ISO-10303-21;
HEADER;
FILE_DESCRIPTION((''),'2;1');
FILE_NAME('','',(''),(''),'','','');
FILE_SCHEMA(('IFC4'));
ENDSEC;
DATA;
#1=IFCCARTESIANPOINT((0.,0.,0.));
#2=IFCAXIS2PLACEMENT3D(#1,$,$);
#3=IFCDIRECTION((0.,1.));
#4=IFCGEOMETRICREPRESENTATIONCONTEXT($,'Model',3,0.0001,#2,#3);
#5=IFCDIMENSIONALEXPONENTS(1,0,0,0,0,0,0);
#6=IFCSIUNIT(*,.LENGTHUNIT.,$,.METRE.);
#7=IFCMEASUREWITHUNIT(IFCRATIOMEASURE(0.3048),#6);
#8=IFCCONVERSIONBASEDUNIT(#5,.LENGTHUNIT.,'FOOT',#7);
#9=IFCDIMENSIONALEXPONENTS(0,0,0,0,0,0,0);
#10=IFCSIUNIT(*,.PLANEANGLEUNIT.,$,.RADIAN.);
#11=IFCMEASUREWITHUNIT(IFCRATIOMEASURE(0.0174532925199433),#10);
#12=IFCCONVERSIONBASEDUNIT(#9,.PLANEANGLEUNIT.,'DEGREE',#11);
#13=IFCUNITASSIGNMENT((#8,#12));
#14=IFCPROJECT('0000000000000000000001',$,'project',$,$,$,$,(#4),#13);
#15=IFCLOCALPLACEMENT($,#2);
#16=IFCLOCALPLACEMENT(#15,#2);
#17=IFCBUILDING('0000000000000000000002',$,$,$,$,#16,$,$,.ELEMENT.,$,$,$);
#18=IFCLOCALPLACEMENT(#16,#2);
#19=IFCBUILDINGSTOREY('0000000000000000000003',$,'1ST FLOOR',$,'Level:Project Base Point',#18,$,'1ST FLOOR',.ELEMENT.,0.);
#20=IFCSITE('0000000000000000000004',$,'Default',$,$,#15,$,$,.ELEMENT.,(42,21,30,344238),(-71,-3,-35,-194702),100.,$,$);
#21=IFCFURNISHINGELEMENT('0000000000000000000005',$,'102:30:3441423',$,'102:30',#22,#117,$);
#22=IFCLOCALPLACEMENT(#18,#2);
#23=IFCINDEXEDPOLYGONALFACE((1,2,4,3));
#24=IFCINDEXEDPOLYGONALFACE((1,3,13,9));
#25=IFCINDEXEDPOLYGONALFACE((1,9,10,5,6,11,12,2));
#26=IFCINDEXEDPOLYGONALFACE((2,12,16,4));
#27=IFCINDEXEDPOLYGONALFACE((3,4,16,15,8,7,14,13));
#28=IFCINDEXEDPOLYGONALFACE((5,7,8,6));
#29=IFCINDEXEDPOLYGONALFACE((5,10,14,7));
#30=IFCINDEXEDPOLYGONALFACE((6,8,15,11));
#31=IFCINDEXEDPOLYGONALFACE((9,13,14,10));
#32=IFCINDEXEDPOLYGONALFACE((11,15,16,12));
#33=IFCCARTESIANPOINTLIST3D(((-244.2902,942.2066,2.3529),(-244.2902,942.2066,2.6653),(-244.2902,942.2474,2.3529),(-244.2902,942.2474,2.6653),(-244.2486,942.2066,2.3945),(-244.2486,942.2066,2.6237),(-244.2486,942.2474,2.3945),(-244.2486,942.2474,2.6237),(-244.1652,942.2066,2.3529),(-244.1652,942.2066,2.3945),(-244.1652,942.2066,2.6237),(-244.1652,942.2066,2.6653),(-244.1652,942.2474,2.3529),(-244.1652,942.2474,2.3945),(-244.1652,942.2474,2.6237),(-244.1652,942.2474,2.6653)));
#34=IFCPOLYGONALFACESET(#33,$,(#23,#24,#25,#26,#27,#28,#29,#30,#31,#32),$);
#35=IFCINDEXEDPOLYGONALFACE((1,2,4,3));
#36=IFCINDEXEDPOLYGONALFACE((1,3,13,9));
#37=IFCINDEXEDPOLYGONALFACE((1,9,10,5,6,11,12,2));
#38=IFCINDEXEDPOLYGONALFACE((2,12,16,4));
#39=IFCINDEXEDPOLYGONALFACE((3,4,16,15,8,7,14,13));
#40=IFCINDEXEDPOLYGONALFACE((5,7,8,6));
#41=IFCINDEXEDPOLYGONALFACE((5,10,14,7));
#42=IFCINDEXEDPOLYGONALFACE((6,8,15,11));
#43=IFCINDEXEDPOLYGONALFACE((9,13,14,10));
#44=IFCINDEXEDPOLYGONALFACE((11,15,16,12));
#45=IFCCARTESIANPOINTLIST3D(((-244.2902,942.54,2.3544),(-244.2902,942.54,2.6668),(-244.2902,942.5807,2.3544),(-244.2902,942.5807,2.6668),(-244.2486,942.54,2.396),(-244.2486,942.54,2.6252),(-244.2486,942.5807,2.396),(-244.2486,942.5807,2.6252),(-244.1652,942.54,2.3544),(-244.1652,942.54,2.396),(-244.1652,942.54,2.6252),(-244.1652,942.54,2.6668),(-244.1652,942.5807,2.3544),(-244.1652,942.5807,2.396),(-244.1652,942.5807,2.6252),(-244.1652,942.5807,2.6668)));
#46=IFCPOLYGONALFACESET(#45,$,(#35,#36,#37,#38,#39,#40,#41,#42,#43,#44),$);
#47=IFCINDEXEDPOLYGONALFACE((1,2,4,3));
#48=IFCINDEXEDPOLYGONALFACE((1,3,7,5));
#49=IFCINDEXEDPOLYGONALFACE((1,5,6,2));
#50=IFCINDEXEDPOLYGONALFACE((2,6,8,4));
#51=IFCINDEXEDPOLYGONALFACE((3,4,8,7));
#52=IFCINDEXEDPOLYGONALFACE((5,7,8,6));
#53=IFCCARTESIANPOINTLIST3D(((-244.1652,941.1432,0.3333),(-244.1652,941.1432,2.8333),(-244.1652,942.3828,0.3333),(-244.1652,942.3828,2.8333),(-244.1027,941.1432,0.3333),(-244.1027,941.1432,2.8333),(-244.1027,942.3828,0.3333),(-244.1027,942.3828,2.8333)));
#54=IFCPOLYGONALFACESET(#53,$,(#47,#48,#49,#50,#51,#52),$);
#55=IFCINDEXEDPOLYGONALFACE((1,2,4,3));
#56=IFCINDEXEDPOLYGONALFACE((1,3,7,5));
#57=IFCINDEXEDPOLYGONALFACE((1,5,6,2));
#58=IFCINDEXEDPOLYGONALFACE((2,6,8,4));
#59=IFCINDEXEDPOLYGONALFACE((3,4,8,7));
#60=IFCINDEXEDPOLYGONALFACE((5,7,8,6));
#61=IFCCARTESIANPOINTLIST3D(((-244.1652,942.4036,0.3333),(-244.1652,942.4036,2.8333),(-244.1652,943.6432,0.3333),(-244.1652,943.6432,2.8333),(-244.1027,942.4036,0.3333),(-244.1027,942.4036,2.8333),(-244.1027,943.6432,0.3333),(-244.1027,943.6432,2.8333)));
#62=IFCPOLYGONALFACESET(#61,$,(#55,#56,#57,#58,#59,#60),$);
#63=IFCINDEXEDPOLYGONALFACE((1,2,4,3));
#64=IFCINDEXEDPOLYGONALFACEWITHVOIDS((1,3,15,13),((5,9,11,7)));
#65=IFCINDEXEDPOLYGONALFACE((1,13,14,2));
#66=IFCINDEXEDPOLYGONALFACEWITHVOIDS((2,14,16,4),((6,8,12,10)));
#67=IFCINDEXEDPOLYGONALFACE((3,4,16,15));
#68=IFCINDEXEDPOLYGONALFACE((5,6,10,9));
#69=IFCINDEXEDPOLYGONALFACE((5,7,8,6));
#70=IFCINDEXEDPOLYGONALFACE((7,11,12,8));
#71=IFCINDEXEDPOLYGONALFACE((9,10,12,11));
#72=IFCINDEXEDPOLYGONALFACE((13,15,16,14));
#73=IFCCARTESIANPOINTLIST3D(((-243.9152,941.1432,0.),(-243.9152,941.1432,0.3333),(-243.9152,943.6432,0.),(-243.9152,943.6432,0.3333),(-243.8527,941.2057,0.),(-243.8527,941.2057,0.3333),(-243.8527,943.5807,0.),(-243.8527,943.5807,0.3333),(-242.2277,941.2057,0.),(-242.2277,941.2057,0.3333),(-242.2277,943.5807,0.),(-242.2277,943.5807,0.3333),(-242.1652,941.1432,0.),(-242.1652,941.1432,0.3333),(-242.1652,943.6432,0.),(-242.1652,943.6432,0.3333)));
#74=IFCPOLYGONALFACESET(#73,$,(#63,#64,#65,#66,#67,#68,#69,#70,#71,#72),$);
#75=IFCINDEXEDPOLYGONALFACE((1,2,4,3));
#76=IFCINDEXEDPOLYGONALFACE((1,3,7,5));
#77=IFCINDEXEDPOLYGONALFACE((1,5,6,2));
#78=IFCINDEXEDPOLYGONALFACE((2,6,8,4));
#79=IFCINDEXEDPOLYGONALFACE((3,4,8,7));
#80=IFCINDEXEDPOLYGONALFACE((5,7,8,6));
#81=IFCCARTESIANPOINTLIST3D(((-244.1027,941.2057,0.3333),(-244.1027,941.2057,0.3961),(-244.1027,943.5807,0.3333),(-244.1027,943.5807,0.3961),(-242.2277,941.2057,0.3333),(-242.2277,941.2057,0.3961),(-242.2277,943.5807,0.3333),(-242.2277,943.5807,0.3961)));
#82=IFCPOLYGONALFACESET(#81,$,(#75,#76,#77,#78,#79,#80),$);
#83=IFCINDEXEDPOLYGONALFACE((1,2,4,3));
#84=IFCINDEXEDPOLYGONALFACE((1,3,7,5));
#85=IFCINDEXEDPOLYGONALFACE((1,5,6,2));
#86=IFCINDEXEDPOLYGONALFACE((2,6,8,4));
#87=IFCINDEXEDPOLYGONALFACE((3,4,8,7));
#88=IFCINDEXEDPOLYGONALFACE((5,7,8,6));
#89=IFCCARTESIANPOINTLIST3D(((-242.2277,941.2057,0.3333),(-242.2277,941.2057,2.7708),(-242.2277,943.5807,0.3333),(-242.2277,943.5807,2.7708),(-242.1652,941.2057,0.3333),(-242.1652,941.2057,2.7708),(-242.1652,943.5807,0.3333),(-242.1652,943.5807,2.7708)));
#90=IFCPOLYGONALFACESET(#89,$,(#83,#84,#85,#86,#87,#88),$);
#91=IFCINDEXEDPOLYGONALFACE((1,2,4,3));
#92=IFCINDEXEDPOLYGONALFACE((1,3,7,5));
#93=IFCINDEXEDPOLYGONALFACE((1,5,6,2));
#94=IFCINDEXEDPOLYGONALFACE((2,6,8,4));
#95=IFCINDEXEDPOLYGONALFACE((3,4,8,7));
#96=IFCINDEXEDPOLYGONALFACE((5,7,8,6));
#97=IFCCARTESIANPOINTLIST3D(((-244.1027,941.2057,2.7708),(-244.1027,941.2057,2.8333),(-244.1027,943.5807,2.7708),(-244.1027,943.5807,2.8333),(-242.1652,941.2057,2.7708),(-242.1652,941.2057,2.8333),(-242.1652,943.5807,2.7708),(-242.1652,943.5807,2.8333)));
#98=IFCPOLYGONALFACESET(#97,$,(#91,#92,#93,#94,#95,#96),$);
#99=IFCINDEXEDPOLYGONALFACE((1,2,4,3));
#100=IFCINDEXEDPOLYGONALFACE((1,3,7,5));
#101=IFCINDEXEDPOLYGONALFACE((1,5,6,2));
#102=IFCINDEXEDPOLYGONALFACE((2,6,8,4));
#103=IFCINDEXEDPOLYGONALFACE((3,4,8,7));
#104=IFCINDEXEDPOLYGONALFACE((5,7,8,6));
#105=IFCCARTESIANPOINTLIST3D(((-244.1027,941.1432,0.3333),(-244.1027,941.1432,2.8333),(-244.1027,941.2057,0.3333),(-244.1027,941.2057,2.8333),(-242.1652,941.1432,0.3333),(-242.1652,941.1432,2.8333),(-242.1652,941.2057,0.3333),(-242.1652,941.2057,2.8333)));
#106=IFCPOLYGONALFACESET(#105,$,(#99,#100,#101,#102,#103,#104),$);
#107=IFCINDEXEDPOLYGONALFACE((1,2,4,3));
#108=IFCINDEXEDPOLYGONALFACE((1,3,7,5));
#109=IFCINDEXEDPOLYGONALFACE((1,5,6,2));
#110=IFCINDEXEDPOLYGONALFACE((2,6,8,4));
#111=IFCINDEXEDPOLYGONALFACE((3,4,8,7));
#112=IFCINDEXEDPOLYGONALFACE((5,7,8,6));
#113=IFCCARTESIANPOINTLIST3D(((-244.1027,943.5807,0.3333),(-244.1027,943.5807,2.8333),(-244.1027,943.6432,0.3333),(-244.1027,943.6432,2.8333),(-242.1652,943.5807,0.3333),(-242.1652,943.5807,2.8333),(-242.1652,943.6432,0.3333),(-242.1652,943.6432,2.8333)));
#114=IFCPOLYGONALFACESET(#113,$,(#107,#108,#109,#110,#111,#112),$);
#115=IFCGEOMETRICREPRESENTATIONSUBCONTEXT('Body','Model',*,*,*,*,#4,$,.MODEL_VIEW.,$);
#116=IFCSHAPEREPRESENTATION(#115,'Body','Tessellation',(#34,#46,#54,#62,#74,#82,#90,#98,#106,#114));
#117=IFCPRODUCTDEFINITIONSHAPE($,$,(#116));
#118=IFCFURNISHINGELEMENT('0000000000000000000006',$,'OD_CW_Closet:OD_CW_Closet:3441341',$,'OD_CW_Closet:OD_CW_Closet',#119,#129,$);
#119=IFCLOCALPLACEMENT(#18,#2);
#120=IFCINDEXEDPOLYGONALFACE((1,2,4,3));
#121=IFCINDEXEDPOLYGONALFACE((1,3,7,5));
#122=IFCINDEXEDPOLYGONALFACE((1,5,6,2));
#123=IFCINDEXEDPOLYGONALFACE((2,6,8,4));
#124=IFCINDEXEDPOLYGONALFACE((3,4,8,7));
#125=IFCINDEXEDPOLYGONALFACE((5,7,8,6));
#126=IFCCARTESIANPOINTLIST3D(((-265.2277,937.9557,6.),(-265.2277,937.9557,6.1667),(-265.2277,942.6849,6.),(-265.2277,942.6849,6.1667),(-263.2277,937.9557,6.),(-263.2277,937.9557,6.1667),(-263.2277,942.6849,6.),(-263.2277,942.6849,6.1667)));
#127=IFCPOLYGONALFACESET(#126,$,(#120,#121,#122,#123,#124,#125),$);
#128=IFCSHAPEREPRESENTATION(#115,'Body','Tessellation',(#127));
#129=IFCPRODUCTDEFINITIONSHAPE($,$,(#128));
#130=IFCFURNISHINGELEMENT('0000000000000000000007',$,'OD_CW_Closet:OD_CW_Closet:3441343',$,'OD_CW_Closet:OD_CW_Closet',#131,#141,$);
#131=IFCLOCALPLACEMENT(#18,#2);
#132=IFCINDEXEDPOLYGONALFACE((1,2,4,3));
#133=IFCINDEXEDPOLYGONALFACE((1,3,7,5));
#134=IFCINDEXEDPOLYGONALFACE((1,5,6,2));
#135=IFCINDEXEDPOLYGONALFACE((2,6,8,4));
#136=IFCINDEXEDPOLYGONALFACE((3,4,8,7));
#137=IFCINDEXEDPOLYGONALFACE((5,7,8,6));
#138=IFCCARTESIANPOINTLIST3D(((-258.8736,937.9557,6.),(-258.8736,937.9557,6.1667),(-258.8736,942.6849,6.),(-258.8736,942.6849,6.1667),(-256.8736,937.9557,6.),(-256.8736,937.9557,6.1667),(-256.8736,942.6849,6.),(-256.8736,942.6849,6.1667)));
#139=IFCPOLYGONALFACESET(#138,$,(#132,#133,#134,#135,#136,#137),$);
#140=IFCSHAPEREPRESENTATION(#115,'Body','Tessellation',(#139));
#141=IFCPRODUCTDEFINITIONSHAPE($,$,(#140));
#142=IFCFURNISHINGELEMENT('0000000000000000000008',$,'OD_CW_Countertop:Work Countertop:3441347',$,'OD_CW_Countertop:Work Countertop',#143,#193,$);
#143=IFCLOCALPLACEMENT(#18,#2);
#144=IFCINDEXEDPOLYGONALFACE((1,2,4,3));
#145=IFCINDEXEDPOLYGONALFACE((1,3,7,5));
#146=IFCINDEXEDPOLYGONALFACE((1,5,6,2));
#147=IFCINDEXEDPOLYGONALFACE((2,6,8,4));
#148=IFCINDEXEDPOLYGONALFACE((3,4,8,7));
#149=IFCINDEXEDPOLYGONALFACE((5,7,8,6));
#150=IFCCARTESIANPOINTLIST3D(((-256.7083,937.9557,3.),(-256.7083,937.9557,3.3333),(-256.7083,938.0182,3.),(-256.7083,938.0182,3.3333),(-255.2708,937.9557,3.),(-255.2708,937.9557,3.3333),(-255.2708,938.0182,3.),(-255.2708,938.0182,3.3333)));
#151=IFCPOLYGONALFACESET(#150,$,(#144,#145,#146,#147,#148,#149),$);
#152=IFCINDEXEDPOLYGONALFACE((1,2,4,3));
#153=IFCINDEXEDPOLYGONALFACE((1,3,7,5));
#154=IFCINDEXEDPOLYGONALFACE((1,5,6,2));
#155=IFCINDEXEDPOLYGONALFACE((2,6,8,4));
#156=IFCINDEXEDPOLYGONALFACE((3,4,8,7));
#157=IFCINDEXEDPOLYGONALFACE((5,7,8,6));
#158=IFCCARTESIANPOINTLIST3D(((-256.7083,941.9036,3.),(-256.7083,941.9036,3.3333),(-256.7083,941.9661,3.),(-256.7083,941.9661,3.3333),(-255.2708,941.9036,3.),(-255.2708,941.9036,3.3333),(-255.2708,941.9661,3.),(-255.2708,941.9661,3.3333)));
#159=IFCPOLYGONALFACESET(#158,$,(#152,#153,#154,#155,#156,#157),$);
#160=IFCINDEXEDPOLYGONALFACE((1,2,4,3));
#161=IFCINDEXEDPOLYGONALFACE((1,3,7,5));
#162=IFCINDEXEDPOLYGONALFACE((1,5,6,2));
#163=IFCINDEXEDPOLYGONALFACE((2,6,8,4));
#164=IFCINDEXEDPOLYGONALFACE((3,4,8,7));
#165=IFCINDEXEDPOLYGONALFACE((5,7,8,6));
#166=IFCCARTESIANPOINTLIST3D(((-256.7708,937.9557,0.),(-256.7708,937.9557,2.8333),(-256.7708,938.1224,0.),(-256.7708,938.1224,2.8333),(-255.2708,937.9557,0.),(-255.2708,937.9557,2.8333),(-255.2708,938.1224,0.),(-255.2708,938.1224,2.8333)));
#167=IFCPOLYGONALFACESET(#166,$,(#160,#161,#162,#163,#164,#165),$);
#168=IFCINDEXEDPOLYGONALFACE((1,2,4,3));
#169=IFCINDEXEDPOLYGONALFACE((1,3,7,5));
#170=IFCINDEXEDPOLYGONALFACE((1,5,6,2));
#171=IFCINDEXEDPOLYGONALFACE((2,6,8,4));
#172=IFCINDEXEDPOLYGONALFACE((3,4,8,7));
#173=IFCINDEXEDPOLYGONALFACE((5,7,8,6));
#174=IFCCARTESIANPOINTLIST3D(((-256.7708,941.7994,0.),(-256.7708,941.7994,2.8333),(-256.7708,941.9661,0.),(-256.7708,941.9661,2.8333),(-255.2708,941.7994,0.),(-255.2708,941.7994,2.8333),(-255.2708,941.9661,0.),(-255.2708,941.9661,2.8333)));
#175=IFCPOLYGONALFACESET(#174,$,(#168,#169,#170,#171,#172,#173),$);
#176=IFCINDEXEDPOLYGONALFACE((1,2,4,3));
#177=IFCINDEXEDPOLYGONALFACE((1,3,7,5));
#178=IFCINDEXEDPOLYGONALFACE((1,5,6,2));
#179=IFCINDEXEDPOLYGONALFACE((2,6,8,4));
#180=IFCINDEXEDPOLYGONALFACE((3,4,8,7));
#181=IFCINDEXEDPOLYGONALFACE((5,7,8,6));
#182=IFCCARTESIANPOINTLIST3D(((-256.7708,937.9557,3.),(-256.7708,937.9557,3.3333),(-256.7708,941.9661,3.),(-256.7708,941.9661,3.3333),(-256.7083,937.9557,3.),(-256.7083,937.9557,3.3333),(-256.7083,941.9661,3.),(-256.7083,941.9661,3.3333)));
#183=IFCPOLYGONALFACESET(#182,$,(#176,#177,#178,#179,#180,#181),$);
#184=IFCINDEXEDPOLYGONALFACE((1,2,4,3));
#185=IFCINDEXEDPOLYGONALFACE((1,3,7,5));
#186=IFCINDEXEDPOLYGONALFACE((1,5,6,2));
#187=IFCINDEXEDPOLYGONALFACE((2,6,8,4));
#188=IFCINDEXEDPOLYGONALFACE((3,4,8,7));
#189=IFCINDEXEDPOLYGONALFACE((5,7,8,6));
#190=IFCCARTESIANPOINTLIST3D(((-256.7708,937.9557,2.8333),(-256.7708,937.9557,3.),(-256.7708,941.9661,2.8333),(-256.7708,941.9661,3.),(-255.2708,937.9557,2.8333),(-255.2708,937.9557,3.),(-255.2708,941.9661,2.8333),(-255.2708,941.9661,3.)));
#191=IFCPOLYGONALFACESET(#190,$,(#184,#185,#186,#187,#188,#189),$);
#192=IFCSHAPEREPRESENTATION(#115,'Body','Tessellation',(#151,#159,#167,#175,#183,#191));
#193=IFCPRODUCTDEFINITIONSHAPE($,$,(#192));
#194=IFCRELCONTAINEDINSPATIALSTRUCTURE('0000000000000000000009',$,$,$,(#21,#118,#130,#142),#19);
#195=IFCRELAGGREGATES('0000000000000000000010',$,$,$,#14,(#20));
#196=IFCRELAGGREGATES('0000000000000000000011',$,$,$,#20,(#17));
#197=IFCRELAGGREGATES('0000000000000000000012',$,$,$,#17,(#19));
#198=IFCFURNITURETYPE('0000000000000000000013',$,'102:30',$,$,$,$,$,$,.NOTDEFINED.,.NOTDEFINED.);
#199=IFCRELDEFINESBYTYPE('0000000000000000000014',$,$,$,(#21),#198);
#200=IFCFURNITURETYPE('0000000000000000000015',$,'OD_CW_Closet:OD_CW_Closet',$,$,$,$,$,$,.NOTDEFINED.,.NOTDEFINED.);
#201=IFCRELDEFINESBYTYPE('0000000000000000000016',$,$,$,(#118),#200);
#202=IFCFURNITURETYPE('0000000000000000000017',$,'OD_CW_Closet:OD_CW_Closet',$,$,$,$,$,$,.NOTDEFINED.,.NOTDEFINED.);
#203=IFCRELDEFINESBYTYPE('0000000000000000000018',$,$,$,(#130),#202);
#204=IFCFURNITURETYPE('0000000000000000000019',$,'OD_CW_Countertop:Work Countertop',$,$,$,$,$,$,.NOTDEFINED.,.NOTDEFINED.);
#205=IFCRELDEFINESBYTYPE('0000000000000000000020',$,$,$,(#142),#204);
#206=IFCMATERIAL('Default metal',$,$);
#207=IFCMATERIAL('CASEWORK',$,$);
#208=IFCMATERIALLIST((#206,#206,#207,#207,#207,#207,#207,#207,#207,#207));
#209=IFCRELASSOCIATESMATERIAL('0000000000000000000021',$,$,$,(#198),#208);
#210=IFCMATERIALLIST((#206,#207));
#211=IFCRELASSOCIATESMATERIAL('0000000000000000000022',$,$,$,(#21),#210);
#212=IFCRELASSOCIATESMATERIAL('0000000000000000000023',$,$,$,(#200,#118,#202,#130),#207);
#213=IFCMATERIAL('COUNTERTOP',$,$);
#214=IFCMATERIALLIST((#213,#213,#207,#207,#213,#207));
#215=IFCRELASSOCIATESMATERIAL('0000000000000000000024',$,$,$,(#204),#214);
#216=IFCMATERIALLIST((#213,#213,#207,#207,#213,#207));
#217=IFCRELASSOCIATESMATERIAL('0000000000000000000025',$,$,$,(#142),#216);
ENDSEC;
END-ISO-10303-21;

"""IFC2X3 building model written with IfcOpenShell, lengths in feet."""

from ifc_helpers import new_model, entity, si_unit, converted_unit, direction, frame, frame_2d, origin, origin_2d_with_axis, place, context, subcontext, project, spatial, polyline, rectangle, outline, extrude, source, transform, mapped, material, material_list, type_object, type_shapes, element, save


model = new_model("IFC2X3")

# Units and contexts
model_context = context("Model", 3, precision=0.0001, world=origin(), true_north=direction((0.0, 1.0)))
body_context = subcontext(model_context, "Body", "Model", "MODEL_VIEW")
ifc_project = project(units=[converted_unit("LENGTHUNIT", "FOOT", entity("IfcRatioMeasure", 0.3048), si_unit("LENGTHUNIT", "METRE"), dimensions=[1, 0, 0, 0, 0, 0, 0]), converted_unit("PLANEANGLEUNIT", "DEGREE", entity("IfcRatioMeasure", 0.0174532925199433), si_unit("PLANEANGLEUNIT", "RADIAN"), dimensions=[0, 0, 0, 0, 0, 0, 0])], contexts=[model_context])

# Site, building, storey
site_placement = place(None, origin())
site = spatial("IfcSite", under=ifc_project, at=site_placement, Name="Default", CompositionType="ELEMENT", RefLatitude=(42, 21, 30, 344238), RefLongitude=(-71, -3, -35, -194702), RefElevation=100.0)
building_placement = place(site_placement, origin())
building = spatial("IfcBuilding", under=site, at=building_placement, CompositionType="ELEMENT")
storey_placement = place(building_placement, origin())
storey = spatial("IfcBuildingStorey", under=building, at=storey_placement, Name="1ST FLOOR", ObjectType="Level:Project Base Point", LongName="1ST FLOOR", CompositionType="ELEMENT", Elevation=0.0)

# Furnishing elements
ifc_material_1 = material(Name="Default metal")
ifc_material_2 = material(Name="CASEWORK")
ifc_material_list_1 = material_list([ifc_material_1, ifc_material_2])
ifc_material_list_2 = material_list([ifc_material_1, ifc_material_1, ifc_material_2, ifc_material_2, ifc_material_2, ifc_material_2, ifc_material_2, ifc_material_2, ifc_material_2, ifc_material_2])
furniture_type_1 = type_object("IfcFurnitureType", Name="102:30", material=ifc_material_list_2)
shared_shape_1 = source(origin(), body_context, "Body", "SweptSolid", [
    extrude(outline(polyline([(0.1146, -0.0521), (0.1562, -0.0521), (0.1562, 0.0729), (-0.1562, 0.0729), (-0.1562, -0.0521), (-0.1146, -0.0521), (-0.1146, 0.0313), (0.1146, 0.0313), (0.1146, -0.0521)])), frame((0.2073, -2.0521, 2.5091), z_axis=(1.0, 0.0, 0.0), x_axis=(0.0, 0.0, 1.0)), (0.0, 0.0, 1.0), 0.0407),
    extrude(outline(polyline([(0.1146, -0.0521), (0.1562, -0.0521), (0.1562, 0.0729), (-0.1562, 0.0729), (-0.1562, -0.0521), (-0.1146, -0.0521), (-0.1146, 0.0313), (0.1146, 0.0313), (0.1146, -0.0521)])), frame((-0.126, -2.0521, 2.5106), z_axis=(1.0, 0.0, 0.0), x_axis=(0.0, 0.0, 1.0)), (0.0, 0.0, 1.0), 0.0407),
    extrude(rectangle(XDim=0.0625, YDim=1.2396, at=frame_2d((0.0, 0.0), x_axis=(1.0, 0.0))), frame((0.6917, -1.9688, 0.3333), z_axis=(0.0, 0.0, 1.0), x_axis=(0.0, 1.0, 0.0)), (0.0, 0.0, 1.0), 2.5),
    extrude(rectangle(XDim=0.0625, YDim=1.2396, at=origin_2d_with_axis()), frame((-0.5687, -1.9688, 0.3333), z_axis=(0.0, 0.0, 1.0), x_axis=(0.0, 1.0, 0.0)), (0.0, 0.0, 1.0), 2.5),
    extrude(outline(polyline([(-1.25, -0.875), (1.25, -0.875), (1.25, 0.875), (-1.25, 0.875), (-1.25, -0.875)]), holes=[polyline([(-1.1875, -0.8125), (-1.1875, 0.8125), (1.1875, 0.8125), (1.1875, -0.8125), (-1.1875, -0.8125)])]), frame((0.0615, -0.875, 0.0)), (0.0, 0.0, 1.0), 0.3333),
    extrude(rectangle(XDim=2.375, YDim=1.875, at=frame_2d((0.0, 0.0), x_axis=(1.0, 0.0))), frame((0.0615, -1.0, 0.3333), z_axis=(0.0, 0.0, 1.0), x_axis=(-1.0, 0.0, 0.0)), (0.0, 0.0, 1.0), 0.0627),
    extrude(rectangle(XDim=0.0625, YDim=2.375, at=origin_2d_with_axis()), frame((0.0615, -0.0312, 0.3333), z_axis=(0.0, 0.0, 1.0), x_axis=(0.0, 1.0, 0.0)), (0.0, 0.0, 1.0), 2.4375),
    extrude(rectangle(XDim=2.375, YDim=1.9375, at=origin_2d_with_axis()), frame((0.0615, -0.9688, 2.7708), z_axis=(0.0, 0.0, 1.0), x_axis=(-1.0, 0.0, 0.0)), (0.0, 0.0, 1.0), 0.0625),
    extrude(rectangle(XDim=0.0625, YDim=1.9375, at=frame_2d((0.0, 0.0), x_axis=(1.0, 0.0))), frame((1.2802, -0.9687, 0.3333)), (0.0, 0.0, 1.0), 2.5),
    extrude(rectangle(XDim=0.0625, YDim=1.9375, at=frame_2d((0.0, 0.0), x_axis=(1.0, 0.0))), frame((-1.1573, -0.9687, 0.3333)), (0.0, 0.0, 1.0), 2.5),
])
type_shapes(furniture_type_1, [shared_shape_1])
furnishing_1_placement = place(storey_placement, frame((-242.1652, 942.4547, 0.0), z_axis=(0.0, 0.0, 1.0), x_axis=(0.0, -1.0, 0.0)))
element("IfcFurnishingElement", 1, at=furnishing_1_placement, inside=storey, type_object=furniture_type_1, material=ifc_material_list_1, Name="102:30:3441423", ObjectType="102:30", context=body_context, shape_type="MappedRepresentation", body=[
    mapped(shared_shape_1, transform((0.0, 0.0, 0.0), scale=1.0)),
])
furniture_type_2 = type_object("IfcFurnitureType", Name="OD_CW_Closet:OD_CW_Closet", material=ifc_material_2)
shared_shape_2 = source(origin(), body_context, "Body", "SweptSolid", [
    extrude(rectangle(XDim=2.0, YDim=4.7292, at=origin_2d_with_axis()), frame((2.3646, 1.0, 0.0), z_axis=(0.0, 0.0, 1.0), x_axis=(0.0, -1.0, 0.0)), (0.0, 0.0, 1.0), 0.1667),
])
type_shapes(furniture_type_2, [shared_shape_2])
furnishing_2_placement = place(storey_placement, frame((-263.2277, 937.9557, 6.0), z_axis=(0.0, 0.0, 1.0), x_axis=(0.0, 1.0, 0.0)))
element("IfcFurnishingElement", 2, at=furnishing_2_placement, inside=storey, type_object=furniture_type_2, material=ifc_material_2, Name="OD_CW_Closet:OD_CW_Closet:3441341", ObjectType="OD_CW_Closet:OD_CW_Closet", context=body_context, shape_type="MappedRepresentation", body=[
    mapped(shared_shape_2, transform((0.0, 0.0, 0.0), scale=1.0)),
])
furniture_type_3 = type_object("IfcFurnitureType", Name="OD_CW_Closet:OD_CW_Closet", material=ifc_material_2)
shared_shape_3 = source(origin(), body_context, "Body", "SweptSolid", [
    extrude(rectangle(XDim=4.7292, YDim=2.0, at=origin_2d_with_axis()), frame((2.3646, 1.0, 0.0)), (0.0, 0.0, 1.0), 0.1667),
])
type_shapes(furniture_type_3, [shared_shape_3])
furnishing_3_placement = place(storey_placement, frame((-256.8736, 937.9557, 6.0), z_axis=(0.0, 0.0, 1.0), x_axis=(0.0, 1.0, 0.0)))
element("IfcFurnishingElement", 3, at=furnishing_3_placement, inside=storey, type_object=furniture_type_3, material=ifc_material_2, Name="OD_CW_Closet:OD_CW_Closet:3441343", ObjectType="OD_CW_Closet:OD_CW_Closet", context=body_context, shape_type="MappedRepresentation", body=[
    mapped(shared_shape_3, transform((0.0, 0.0, 0.0), scale=1.0)),
])
ifc_material_3 = material(Name="COUNTERTOP")
ifc_material_list_3 = material_list([ifc_material_3, ifc_material_3, ifc_material_2, ifc_material_2, ifc_material_3, ifc_material_2])
ifc_material_list_4 = material_list([ifc_material_3, ifc_material_3, ifc_material_2, ifc_material_2, ifc_material_3, ifc_material_2])
furniture_type_4 = type_object("IfcFurnitureType", Name="OD_CW_Countertop:Work Countertop", material=ifc_material_list_4)
shared_shape_4 = source(origin(), body_context, "Body", "SweptSolid", [
    extrude(rectangle(XDim=1.4375, YDim=0.0625, at=origin_2d_with_axis()), frame((3.9792, 0.7812, 3.0), z_axis=(0.0, 0.0, 1.0), x_axis=(0.0, 1.0, 0.0)), (0.0, 0.0, 1.0), 0.3333),
    extrude(rectangle(XDim=1.4375, YDim=0.0625, at=origin_2d_with_axis()), frame((0.0313, 0.7813, 3.0), z_axis=(0.0, 0.0, 1.0), x_axis=(0.0, 1.0, 0.0)), (0.0, 0.0, 1.0), 0.3333),
    extrude(rectangle(XDim=0.1667, YDim=1.5, at=frame_2d((0.0, 0.0), x_axis=(1.0, 0.0))), frame((3.9271, 0.75, 0.0)), (0.0, 0.0, 1.0), 2.8333),
    extrude(rectangle(XDim=0.1667, YDim=1.5, at=origin_2d_with_axis()), frame((0.0833, 0.75, 0.0)), (0.0, 0.0, 1.0), 2.8333),
    extrude(rectangle(XDim=4.0104, YDim=0.0625, at=frame_2d((0.0, 0.0), x_axis=(1.0, 0.0))), frame((2.0052, 0.0313, 3.0)), (0.0, 0.0, 1.0), 0.3333),
    extrude(rectangle(XDim=4.0104, YDim=1.5, at=frame_2d((0.0, 0.0), x_axis=(1.0, 0.0))), frame((2.0052, 0.75, 2.8333)), (0.0, 0.0, 1.0), 0.1667),
])
type_shapes(furniture_type_4, [shared_shape_4])
furnishing_4_placement = place(storey_placement, frame((-256.7708, 941.9661, 0.0), z_axis=(0.0, 0.0, 1.0), x_axis=(0.0, -1.0, 0.0)))
element("IfcFurnishingElement", 4, at=furnishing_4_placement, inside=storey, type_object=furniture_type_4, material=ifc_material_list_3, Name="OD_CW_Countertop:Work Countertop:3441347", ObjectType="OD_CW_Countertop:Work Countertop", context=body_context, shape_type="MappedRepresentation", body=[
    mapped(shared_shape_4, transform((0.0, 0.0, 0.0), scale=1.0)),
])

save(model, "model.ifc")
